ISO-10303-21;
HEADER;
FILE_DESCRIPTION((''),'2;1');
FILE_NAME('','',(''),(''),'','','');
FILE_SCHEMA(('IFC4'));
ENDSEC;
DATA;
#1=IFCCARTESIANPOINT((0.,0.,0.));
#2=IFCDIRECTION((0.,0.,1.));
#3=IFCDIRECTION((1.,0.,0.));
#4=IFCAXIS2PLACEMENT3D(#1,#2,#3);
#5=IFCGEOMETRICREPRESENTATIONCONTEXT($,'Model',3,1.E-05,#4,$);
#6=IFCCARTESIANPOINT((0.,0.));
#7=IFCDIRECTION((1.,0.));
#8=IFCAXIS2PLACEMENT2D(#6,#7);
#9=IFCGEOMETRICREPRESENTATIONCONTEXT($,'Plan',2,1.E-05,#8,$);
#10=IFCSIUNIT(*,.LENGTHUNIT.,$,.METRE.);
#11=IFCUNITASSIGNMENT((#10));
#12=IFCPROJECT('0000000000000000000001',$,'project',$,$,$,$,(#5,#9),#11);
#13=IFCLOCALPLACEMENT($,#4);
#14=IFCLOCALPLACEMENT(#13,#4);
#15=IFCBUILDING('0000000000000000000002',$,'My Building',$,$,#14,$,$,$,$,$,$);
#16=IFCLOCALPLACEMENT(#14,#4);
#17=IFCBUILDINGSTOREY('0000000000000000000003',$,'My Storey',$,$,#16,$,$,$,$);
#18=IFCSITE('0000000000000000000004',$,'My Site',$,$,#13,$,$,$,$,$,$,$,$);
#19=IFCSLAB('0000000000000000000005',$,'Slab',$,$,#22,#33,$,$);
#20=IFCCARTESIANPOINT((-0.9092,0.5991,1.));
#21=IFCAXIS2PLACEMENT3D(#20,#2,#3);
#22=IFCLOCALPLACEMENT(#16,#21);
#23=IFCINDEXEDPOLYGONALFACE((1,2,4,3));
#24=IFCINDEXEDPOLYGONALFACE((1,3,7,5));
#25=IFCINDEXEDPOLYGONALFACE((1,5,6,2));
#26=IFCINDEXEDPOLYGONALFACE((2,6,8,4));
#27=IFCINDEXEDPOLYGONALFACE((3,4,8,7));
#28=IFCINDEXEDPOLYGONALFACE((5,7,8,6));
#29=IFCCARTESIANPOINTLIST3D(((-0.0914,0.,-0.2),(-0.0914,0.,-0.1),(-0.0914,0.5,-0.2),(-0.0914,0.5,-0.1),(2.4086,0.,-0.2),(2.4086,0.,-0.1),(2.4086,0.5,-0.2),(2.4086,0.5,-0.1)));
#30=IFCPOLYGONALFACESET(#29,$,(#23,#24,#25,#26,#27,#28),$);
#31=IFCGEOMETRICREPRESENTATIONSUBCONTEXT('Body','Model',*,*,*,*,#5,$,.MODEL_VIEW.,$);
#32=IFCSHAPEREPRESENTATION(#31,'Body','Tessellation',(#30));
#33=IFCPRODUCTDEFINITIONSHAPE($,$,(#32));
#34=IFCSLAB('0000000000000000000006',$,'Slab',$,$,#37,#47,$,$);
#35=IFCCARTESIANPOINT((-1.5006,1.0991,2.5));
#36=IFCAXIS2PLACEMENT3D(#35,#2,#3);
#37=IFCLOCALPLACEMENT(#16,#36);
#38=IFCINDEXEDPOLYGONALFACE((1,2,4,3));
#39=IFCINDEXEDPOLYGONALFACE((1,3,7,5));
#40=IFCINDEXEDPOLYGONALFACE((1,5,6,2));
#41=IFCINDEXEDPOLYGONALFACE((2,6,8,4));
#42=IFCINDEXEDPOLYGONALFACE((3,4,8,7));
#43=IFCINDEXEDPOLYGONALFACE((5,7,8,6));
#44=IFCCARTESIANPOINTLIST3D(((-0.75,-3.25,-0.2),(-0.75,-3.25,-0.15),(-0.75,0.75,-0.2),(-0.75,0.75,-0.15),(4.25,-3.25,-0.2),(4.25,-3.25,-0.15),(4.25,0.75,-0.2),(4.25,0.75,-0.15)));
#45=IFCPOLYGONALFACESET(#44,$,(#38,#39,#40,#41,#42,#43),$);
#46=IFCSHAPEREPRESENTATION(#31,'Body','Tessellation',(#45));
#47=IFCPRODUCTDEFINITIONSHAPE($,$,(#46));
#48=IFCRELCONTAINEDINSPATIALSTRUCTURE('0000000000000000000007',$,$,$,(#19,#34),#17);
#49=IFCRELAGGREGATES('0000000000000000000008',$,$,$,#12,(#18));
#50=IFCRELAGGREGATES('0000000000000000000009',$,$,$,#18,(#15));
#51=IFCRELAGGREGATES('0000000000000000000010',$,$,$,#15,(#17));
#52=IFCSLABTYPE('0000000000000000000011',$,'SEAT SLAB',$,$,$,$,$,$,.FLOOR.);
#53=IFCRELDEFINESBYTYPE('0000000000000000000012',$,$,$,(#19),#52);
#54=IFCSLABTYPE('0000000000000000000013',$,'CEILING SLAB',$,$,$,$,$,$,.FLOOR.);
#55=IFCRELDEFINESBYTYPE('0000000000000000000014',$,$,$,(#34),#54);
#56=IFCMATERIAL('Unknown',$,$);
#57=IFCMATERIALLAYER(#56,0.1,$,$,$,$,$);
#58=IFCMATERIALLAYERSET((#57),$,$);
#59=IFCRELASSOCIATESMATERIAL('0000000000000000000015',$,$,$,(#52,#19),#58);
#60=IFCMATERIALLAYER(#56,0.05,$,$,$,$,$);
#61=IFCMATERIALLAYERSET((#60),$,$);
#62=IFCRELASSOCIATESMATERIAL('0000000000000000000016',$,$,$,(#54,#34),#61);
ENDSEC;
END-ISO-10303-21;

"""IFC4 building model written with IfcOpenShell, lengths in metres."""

from ifc_helpers import new_model, si_unit, frame, origin_with_axes, origin_2d_with_axis, place, context, subcontext, project, spatial, indexed_curve, outline, extrude, material, layer, layer_set, layer_usage, type_object, element, save


model = new_model("IFC4")

# Units and contexts
model_context = context("Model", 3, precision=1e-05, world=origin_with_axes())
plan_context = context("Plan", 2, precision=1e-05, world=origin_2d_with_axis())
body_context = subcontext(model_context, "Body", "Model", "MODEL_VIEW")
ifc_project = project(units=[si_unit("LENGTHUNIT", "METRE")], contexts=[model_context, plan_context])

# Site, building, storey
site_placement = place(None, origin_with_axes())
site = spatial("IfcSite", under=ifc_project, at=site_placement, Name="My Site")
building_placement = place(site_placement, origin_with_axes())
building = spatial("IfcBuilding", under=site, at=building_placement, Name="My Building")
storey_placement = place(building_placement, origin_with_axes())
storey = spatial("IfcBuildingStorey", under=building, at=storey_placement, Name="My Storey")

# Slabs
ifc_material = material(Name="Unknown")
ifc_layer_1 = layer(ifc_material, 0.1)
ifc_layer_set_1 = layer_set([ifc_layer_1])
slab_type_1 = type_object("IfcSlabType", Name="SEAT SLAB", PredefinedType="FLOOR", material=ifc_layer_set_1)
ifc_layer_usage_1 = layer_usage(ifc_layer_set_1, "AXIS3", "POSITIVE", -0.2)
slab_1_placement = place(storey_placement, frame((-0.9092, 0.5991, 1.0), z_axis=(0.0, 0.0, 1.0), x_axis=(1.0, 0.0, 0.0)))
element("IfcSlab", 1, at=slab_1_placement, inside=storey, type_object=slab_type_1, material=ifc_layer_usage_1, Name="Slab", context=body_context, shape_type="SweptSolid", body=[
    extrude(outline(indexed_curve([(-0.0914, 0.0), (-0.0914, 0.5), (2.4086, 0.5), (2.4086, 0.0), (-0.0914, 0.0)])), frame((0.0, 0.0, -0.2), z_axis=(0.0, 0.0, 1.0), x_axis=(1.0, 0.0, 0.0)), (0.0, 0.0, 1.0), 0.1),
])
ifc_layer_2 = layer(ifc_material, 0.05)
ifc_layer_set_2 = layer_set([ifc_layer_2])
ifc_layer_usage_2 = layer_usage(ifc_layer_set_2, "AXIS3", "POSITIVE", -0.2)
slab_type_2 = type_object("IfcSlabType", Name="CEILING SLAB", PredefinedType="FLOOR", material=ifc_layer_set_2)
slab_2_placement = place(storey_placement, frame((-1.5006, 1.0991, 2.5), z_axis=(0.0, 0.0, 1.0), x_axis=(1.0, 0.0, 0.0)))
element("IfcSlab", 2, at=slab_2_placement, inside=storey, type_object=slab_type_2, material=ifc_layer_usage_2, Name="Slab", context=body_context, shape_type="SweptSolid", body=[
    extrude(outline(indexed_curve([(-0.75, 0.75), (-0.75, -3.25), (4.25, -3.25), (4.25, 0.75), (-0.75, 0.75)])), frame((0.0, 0.0, -0.2), z_axis=(0.0, 0.0, 1.0), x_axis=(1.0, 0.0, 0.0)), (0.0, 0.0, 1.0), 0.05),
])

save(model, "model.ifc")
